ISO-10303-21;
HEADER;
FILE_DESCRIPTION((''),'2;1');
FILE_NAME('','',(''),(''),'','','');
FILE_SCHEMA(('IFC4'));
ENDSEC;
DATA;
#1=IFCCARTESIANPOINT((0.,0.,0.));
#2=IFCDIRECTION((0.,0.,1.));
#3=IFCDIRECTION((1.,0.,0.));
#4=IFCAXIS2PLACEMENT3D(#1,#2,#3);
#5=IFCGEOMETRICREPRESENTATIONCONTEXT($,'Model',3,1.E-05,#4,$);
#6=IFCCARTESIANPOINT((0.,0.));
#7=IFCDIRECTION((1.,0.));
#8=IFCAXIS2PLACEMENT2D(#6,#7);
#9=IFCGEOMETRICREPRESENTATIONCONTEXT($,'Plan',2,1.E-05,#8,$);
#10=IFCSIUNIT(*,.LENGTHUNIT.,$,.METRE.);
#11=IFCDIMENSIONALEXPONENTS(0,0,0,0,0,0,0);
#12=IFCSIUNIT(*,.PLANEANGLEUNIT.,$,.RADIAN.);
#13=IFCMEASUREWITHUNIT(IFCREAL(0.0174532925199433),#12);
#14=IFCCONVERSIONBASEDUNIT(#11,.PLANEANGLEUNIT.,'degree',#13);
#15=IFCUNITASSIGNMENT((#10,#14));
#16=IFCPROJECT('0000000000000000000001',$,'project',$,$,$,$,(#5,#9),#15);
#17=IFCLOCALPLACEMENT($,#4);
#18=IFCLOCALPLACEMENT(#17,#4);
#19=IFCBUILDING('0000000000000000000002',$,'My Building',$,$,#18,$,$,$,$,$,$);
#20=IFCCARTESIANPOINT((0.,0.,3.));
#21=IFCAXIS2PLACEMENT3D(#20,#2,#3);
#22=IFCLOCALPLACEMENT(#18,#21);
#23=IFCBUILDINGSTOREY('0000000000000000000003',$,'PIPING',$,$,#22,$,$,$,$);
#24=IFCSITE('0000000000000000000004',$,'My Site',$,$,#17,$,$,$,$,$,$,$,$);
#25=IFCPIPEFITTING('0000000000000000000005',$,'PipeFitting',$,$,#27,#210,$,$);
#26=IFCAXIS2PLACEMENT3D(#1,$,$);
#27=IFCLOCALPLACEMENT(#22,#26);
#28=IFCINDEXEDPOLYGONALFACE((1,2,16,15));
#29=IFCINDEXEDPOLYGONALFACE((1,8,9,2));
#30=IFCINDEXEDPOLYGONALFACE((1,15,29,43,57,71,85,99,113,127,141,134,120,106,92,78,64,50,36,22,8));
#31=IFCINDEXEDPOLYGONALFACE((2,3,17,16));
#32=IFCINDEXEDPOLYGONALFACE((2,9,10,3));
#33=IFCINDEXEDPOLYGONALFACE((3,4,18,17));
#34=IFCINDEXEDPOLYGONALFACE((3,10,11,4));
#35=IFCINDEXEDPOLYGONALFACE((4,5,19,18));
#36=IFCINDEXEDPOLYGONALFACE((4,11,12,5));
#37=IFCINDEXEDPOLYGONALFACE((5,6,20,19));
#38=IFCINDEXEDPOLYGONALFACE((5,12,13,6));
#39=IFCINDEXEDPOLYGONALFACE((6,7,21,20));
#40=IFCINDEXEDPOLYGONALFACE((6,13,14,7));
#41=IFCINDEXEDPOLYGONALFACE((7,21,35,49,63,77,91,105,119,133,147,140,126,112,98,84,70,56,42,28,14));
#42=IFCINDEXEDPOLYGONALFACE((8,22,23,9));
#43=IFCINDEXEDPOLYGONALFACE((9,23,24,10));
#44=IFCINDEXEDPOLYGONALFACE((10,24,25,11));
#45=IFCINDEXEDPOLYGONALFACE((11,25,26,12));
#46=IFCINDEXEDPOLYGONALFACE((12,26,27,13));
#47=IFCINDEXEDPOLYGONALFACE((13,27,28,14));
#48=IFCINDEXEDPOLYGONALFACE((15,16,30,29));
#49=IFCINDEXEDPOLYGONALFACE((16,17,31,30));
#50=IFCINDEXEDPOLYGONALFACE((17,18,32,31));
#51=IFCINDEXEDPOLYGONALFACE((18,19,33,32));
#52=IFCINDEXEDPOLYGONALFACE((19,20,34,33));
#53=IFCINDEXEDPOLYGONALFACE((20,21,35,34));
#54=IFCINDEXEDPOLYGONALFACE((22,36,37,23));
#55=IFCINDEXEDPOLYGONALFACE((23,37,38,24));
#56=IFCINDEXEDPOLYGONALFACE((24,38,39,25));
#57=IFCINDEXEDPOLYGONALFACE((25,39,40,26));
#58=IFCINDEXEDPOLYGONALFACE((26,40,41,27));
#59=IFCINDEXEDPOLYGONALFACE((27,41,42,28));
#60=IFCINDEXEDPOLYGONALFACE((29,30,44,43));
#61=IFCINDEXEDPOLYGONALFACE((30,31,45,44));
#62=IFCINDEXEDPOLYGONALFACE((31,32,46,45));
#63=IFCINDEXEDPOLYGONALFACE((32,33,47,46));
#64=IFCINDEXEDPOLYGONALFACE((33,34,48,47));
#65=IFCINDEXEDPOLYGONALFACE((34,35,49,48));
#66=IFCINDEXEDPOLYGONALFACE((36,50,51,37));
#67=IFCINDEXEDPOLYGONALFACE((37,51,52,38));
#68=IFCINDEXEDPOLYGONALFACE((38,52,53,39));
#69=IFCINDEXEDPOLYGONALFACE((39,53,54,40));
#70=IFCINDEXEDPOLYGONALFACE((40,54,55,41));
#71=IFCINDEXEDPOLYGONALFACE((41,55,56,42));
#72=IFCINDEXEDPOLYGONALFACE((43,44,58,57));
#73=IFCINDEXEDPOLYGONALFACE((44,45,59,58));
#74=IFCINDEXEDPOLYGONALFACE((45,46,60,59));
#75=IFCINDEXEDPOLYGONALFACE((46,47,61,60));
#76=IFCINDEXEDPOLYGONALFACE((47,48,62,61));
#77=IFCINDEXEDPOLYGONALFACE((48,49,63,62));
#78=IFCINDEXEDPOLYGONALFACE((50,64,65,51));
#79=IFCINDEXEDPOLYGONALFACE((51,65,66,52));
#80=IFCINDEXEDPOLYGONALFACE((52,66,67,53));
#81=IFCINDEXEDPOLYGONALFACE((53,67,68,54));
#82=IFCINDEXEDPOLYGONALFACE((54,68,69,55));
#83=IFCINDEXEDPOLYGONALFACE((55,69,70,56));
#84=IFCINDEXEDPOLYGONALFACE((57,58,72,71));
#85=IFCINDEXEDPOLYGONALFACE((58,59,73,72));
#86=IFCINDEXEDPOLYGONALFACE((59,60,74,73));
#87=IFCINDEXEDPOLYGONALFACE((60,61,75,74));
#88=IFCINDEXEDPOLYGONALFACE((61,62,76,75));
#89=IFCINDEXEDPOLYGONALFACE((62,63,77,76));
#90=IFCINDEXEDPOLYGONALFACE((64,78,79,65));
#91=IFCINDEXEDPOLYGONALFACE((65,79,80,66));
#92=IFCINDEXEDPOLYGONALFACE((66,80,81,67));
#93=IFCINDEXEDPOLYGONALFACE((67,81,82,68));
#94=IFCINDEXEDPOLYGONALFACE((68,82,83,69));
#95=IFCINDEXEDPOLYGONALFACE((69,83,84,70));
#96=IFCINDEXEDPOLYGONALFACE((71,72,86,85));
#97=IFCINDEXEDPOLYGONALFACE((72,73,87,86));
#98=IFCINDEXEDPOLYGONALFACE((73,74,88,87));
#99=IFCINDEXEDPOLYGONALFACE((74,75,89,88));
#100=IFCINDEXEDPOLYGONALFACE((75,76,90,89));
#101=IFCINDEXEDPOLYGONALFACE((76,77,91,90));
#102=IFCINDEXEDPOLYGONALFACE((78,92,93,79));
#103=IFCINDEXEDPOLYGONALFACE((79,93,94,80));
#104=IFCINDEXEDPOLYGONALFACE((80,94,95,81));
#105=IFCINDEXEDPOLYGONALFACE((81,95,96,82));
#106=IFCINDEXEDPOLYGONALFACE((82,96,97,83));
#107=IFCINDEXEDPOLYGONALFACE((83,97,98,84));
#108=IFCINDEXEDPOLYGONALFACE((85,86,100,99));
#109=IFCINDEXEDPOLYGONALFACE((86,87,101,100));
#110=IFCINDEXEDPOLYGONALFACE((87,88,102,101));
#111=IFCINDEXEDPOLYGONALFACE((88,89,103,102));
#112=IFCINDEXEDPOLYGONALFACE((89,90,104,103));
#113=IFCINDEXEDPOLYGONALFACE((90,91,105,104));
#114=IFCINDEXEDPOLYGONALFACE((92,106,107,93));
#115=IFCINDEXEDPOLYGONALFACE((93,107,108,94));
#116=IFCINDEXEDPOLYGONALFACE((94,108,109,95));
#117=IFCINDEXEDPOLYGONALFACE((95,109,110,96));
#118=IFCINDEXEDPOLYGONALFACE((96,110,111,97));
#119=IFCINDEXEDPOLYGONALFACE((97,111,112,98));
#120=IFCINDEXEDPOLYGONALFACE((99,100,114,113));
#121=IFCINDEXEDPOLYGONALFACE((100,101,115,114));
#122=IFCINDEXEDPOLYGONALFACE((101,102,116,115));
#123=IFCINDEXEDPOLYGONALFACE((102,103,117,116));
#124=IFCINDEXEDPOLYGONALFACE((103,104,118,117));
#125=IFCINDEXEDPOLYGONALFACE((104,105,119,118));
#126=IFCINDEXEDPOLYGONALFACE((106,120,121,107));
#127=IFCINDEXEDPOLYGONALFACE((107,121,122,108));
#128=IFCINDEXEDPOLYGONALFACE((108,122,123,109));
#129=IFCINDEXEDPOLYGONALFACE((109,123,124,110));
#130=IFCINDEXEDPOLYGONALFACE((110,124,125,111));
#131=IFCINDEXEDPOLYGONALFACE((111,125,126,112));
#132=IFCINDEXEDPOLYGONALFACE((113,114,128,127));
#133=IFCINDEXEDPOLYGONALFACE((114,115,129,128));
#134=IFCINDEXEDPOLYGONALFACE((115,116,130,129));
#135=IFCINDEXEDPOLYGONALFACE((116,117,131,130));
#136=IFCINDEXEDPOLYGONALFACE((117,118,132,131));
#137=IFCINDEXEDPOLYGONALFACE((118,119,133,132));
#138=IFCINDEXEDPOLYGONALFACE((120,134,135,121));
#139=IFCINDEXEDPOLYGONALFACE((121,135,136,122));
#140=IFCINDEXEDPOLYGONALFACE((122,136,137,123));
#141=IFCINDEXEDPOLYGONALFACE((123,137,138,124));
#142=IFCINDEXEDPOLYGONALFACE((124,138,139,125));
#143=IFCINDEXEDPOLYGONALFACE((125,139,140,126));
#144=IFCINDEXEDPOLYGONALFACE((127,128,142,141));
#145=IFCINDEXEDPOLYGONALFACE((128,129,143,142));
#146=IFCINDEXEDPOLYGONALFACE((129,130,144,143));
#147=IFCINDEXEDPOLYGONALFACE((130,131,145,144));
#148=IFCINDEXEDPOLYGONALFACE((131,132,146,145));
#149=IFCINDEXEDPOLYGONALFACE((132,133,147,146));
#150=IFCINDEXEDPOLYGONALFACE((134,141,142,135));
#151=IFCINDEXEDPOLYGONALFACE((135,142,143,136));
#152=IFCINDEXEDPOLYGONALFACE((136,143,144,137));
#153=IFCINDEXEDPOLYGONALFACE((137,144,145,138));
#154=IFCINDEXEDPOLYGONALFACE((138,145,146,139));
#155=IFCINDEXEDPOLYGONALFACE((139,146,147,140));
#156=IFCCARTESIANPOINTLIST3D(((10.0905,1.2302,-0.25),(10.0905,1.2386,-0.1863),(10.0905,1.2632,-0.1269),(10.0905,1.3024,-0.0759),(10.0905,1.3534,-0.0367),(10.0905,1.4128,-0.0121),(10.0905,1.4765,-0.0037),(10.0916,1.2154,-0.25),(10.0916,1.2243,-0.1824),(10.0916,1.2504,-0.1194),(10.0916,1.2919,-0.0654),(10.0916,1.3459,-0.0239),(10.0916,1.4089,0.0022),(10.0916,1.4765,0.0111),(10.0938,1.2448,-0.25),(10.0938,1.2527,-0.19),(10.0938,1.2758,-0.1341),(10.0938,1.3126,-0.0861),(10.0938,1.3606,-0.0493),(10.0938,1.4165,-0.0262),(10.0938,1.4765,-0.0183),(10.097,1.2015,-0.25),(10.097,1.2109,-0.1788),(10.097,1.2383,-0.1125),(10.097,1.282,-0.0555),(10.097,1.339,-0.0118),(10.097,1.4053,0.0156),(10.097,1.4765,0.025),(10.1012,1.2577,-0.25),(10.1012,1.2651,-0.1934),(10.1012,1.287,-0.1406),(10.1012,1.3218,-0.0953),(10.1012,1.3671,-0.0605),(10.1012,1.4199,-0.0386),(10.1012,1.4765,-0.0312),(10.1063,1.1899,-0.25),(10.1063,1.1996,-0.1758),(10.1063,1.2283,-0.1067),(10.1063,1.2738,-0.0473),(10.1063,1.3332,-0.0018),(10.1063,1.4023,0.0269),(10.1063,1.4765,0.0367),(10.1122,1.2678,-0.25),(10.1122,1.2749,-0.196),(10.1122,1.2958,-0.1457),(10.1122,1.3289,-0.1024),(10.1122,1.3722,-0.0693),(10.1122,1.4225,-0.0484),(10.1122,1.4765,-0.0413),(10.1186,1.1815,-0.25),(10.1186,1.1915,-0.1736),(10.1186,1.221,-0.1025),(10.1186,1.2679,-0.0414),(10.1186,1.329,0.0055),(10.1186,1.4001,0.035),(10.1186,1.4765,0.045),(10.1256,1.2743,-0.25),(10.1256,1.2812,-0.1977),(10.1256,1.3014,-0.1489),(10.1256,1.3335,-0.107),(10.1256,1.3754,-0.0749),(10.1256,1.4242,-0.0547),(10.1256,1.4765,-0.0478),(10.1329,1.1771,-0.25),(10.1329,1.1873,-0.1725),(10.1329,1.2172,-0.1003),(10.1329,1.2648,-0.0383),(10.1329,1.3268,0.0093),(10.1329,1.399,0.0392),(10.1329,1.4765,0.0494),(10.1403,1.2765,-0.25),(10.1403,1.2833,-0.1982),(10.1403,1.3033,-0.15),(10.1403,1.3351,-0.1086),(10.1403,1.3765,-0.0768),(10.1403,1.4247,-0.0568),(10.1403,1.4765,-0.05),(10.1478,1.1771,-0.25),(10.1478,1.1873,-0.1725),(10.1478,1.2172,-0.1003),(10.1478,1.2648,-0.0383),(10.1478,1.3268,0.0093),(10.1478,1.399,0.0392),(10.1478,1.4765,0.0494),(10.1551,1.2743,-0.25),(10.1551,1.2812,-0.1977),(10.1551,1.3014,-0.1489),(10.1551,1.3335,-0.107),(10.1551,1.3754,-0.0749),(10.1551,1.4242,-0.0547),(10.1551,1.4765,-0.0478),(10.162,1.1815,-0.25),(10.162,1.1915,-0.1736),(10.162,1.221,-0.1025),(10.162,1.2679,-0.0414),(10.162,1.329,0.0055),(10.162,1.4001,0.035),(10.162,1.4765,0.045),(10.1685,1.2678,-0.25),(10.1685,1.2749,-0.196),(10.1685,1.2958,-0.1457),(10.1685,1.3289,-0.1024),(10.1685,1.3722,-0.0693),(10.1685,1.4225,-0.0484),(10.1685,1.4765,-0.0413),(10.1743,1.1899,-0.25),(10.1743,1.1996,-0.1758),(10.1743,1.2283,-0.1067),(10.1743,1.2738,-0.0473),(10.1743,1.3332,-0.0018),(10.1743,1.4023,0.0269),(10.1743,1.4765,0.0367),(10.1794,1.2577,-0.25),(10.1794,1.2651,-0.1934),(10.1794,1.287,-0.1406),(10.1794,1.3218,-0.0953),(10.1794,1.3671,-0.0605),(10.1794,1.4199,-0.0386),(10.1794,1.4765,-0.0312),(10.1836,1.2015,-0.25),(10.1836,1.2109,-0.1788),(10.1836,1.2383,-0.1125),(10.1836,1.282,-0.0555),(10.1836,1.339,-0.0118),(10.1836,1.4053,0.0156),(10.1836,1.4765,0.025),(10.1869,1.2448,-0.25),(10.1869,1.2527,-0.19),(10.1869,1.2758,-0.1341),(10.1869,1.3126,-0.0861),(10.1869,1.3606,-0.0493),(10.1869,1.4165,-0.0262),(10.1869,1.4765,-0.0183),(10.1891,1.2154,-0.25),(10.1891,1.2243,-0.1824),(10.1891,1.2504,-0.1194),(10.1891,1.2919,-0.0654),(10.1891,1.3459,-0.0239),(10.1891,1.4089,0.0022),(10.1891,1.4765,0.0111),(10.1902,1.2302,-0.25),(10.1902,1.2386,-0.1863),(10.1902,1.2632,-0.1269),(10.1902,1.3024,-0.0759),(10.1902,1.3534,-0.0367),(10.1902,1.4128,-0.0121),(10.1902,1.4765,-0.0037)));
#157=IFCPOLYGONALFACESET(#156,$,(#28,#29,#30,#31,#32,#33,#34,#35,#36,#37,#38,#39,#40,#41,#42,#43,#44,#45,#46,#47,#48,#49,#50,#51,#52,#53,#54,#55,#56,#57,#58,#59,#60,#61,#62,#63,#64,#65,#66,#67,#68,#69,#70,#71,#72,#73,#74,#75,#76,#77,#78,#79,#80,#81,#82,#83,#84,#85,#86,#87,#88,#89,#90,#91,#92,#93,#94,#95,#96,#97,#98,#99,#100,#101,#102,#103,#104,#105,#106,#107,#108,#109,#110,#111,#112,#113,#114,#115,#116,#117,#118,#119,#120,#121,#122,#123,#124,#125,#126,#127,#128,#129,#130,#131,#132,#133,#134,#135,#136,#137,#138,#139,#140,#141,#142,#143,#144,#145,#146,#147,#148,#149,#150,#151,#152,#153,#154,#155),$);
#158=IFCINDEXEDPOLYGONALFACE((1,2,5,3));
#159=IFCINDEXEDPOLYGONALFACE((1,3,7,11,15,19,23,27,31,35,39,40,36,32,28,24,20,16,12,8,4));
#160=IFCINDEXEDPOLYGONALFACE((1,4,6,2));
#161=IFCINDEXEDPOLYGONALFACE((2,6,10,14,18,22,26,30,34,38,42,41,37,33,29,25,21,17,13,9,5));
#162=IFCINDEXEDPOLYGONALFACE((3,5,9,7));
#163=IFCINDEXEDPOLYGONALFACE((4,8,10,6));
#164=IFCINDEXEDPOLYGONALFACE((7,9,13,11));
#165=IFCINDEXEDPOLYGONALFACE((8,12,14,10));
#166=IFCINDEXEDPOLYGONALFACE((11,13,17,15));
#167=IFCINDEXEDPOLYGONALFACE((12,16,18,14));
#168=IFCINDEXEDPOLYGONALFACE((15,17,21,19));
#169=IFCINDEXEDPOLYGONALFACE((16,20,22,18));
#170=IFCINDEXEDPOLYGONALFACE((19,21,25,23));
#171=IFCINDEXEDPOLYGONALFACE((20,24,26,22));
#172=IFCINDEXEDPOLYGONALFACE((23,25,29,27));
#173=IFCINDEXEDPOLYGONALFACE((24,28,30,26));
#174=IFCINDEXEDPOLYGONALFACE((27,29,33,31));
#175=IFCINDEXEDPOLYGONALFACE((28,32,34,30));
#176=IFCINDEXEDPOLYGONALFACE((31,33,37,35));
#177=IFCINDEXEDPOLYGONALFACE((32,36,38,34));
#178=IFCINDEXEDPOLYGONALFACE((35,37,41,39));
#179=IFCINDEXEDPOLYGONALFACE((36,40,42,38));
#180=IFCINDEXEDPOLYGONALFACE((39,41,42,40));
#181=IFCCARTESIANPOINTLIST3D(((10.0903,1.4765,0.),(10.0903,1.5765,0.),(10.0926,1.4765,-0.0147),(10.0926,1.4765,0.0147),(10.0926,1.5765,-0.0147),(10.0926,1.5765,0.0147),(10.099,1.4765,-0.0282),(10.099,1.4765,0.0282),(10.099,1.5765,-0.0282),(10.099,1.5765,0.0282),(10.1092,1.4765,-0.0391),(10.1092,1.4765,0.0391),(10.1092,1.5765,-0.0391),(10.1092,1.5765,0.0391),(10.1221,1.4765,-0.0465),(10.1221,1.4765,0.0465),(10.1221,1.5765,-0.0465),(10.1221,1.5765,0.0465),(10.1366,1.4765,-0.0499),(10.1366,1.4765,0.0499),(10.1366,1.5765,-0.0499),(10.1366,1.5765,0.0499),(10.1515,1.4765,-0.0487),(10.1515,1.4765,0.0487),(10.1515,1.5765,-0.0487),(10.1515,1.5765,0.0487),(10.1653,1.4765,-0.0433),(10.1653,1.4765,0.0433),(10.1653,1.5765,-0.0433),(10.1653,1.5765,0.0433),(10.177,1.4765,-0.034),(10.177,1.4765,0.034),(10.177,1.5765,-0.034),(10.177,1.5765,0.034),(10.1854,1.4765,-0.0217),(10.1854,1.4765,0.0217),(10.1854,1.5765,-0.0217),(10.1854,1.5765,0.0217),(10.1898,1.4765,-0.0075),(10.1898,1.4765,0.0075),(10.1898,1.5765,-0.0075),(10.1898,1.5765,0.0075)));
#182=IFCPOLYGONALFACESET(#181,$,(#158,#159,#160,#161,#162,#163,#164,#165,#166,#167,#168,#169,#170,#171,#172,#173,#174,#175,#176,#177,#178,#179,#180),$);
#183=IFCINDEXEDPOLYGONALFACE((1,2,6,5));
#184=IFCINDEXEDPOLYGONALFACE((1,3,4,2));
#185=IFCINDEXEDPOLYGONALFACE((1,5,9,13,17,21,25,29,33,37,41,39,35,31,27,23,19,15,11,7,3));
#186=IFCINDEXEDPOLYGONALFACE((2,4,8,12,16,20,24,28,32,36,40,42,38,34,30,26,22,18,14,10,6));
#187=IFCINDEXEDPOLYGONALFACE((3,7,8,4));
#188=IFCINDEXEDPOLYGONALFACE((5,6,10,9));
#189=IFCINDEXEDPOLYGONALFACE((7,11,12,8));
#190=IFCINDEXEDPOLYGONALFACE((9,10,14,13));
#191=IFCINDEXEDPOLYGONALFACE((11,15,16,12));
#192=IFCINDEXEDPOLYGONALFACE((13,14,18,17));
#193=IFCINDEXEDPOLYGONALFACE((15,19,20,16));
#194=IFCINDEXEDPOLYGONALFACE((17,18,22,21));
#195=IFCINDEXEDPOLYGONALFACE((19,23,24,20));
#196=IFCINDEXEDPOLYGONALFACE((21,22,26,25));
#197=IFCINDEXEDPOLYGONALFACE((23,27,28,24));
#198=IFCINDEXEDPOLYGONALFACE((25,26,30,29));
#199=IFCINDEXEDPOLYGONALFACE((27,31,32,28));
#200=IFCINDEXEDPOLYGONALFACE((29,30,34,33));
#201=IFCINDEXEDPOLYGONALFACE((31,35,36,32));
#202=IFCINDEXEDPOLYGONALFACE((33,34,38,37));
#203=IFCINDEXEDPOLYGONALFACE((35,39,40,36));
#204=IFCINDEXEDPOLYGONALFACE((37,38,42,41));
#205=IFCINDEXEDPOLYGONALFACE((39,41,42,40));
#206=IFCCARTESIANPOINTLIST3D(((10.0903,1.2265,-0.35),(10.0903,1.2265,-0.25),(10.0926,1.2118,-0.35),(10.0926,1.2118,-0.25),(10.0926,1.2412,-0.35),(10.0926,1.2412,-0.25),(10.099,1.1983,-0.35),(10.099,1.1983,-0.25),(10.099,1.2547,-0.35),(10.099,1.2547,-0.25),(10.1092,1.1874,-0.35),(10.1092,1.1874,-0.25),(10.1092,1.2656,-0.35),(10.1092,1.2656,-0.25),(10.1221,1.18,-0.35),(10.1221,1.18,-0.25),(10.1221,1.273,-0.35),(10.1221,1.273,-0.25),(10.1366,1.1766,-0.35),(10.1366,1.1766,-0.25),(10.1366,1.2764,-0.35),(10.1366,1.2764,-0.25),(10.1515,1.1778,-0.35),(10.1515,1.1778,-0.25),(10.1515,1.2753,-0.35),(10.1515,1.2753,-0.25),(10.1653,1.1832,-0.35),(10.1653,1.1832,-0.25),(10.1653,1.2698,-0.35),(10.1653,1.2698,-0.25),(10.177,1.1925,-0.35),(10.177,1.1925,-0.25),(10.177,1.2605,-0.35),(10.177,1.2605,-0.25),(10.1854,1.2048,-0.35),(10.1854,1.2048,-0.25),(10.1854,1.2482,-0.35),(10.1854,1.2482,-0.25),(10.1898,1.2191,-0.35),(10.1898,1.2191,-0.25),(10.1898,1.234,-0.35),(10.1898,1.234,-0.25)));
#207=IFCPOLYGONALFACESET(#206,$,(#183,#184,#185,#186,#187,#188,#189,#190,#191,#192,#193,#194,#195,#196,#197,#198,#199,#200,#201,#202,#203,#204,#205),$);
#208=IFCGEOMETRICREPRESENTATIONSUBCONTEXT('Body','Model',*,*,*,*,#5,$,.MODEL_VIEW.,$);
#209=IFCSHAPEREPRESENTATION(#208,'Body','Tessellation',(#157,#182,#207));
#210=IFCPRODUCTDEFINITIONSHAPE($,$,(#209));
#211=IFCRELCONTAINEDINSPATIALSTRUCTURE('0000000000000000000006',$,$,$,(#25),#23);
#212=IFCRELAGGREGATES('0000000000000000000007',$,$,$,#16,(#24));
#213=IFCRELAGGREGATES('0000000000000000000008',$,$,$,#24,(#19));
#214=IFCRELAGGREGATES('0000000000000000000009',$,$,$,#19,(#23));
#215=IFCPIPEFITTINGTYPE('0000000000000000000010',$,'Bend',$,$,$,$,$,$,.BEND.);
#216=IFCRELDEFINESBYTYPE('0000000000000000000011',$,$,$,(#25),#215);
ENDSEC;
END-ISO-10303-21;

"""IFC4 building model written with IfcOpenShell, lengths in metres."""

from ifc_helpers import new_model, entity, si_unit, converted_unit, frame, origin_with_axes, origin_2d_with_axis, place, context, subcontext, project, spatial, circle, extrude, source, transform, mapped, type_object, type_shapes, element, save


model = new_model("IFC4")

# Units and contexts
model_context = context("Model", 3, precision=1e-05, world=origin_with_axes())
plan_context = context("Plan", 2, precision=1e-05, world=origin_2d_with_axis())
body_context = subcontext(model_context, "Body", "Model", "MODEL_VIEW")
ifc_project = project(units=[si_unit("LENGTHUNIT", "METRE"), converted_unit("PLANEANGLEUNIT", "degree", entity("IfcReal", 0.0174532925199433), si_unit("PLANEANGLEUNIT", "RADIAN"), dimensions=[0, 0, 0, 0, 0, 0, 0])], contexts=[model_context, plan_context])

# Site, building, storey
site_placement = place(None, origin_with_axes())
site = spatial("IfcSite", under=ifc_project, at=site_placement, Name="My Site")
building_placement = place(site_placement, origin_with_axes())
building = spatial("IfcBuilding", under=site, at=building_placement, Name="My Building")
storey_placement = place(building_placement, frame((0.0, 0.0, 3.0), z_axis=(0.0, 0.0, 1.0), x_axis=(1.0, 0.0, 0.0)))
storey = spatial("IfcBuildingStorey", under=building, at=storey_placement, Name="PIPING")

# Pipe fitting
pipe_fitting_type = type_object("IfcPipeFittingType", Name="Bend", PredefinedType="BEND")
shared_shape = source(origin_with_axes(), body_context, "Body", "SolidModel", [
    entity("IfcSweptDiskSolid", entity("IfcIndexedPolyCurve", entity("IfcCartesianPointList3D", [[0.0, 0.0, -0.1], [0.0, -0.0732, -0.2768], [0.0, -0.25, -0.35]]), [entity("IfcArcIndex", [1, 2, 3])]), 0.05),
    extrude(circle(Radius=0.05), origin_with_axes(), (0.0, 0.0, -1.0), 0.1),
    extrude(circle(Radius=0.05), frame((0.0, -0.25, -0.35), z_axis=(0.0, -1.0, 0.0), x_axis=(1.0, 0.0, 0.0)), (0.0, 0.0, 1.0), 0.1),
])
type_shapes(pipe_fitting_type, [shared_shape])
for number, where, z_axis, x_axis, name in (
    (1, (10.1403, 1.5765, 0.0), (0.0, 1.0, 0.0), (-1.0, 0.0, 0.0), "PipeFitting"),
):
    element("IfcPipeFitting", number, at=place(storey_placement, frame(where, z_axis=z_axis, x_axis=x_axis)), inside=storey, type_object=pipe_fitting_type, Name=name, context=body_context, shape_type="MappedRepresentation", body=[
        mapped(shared_shape, transform((0.0, 0.0, 0.0), x_axis=(1.0, 0.0, 0.0), y_axis=(0.0, 1.0, 0.0), z_axis=(0.0, 0.0, 1.0), scale=1.0)),
    ])

save(model, "model.ifc")
